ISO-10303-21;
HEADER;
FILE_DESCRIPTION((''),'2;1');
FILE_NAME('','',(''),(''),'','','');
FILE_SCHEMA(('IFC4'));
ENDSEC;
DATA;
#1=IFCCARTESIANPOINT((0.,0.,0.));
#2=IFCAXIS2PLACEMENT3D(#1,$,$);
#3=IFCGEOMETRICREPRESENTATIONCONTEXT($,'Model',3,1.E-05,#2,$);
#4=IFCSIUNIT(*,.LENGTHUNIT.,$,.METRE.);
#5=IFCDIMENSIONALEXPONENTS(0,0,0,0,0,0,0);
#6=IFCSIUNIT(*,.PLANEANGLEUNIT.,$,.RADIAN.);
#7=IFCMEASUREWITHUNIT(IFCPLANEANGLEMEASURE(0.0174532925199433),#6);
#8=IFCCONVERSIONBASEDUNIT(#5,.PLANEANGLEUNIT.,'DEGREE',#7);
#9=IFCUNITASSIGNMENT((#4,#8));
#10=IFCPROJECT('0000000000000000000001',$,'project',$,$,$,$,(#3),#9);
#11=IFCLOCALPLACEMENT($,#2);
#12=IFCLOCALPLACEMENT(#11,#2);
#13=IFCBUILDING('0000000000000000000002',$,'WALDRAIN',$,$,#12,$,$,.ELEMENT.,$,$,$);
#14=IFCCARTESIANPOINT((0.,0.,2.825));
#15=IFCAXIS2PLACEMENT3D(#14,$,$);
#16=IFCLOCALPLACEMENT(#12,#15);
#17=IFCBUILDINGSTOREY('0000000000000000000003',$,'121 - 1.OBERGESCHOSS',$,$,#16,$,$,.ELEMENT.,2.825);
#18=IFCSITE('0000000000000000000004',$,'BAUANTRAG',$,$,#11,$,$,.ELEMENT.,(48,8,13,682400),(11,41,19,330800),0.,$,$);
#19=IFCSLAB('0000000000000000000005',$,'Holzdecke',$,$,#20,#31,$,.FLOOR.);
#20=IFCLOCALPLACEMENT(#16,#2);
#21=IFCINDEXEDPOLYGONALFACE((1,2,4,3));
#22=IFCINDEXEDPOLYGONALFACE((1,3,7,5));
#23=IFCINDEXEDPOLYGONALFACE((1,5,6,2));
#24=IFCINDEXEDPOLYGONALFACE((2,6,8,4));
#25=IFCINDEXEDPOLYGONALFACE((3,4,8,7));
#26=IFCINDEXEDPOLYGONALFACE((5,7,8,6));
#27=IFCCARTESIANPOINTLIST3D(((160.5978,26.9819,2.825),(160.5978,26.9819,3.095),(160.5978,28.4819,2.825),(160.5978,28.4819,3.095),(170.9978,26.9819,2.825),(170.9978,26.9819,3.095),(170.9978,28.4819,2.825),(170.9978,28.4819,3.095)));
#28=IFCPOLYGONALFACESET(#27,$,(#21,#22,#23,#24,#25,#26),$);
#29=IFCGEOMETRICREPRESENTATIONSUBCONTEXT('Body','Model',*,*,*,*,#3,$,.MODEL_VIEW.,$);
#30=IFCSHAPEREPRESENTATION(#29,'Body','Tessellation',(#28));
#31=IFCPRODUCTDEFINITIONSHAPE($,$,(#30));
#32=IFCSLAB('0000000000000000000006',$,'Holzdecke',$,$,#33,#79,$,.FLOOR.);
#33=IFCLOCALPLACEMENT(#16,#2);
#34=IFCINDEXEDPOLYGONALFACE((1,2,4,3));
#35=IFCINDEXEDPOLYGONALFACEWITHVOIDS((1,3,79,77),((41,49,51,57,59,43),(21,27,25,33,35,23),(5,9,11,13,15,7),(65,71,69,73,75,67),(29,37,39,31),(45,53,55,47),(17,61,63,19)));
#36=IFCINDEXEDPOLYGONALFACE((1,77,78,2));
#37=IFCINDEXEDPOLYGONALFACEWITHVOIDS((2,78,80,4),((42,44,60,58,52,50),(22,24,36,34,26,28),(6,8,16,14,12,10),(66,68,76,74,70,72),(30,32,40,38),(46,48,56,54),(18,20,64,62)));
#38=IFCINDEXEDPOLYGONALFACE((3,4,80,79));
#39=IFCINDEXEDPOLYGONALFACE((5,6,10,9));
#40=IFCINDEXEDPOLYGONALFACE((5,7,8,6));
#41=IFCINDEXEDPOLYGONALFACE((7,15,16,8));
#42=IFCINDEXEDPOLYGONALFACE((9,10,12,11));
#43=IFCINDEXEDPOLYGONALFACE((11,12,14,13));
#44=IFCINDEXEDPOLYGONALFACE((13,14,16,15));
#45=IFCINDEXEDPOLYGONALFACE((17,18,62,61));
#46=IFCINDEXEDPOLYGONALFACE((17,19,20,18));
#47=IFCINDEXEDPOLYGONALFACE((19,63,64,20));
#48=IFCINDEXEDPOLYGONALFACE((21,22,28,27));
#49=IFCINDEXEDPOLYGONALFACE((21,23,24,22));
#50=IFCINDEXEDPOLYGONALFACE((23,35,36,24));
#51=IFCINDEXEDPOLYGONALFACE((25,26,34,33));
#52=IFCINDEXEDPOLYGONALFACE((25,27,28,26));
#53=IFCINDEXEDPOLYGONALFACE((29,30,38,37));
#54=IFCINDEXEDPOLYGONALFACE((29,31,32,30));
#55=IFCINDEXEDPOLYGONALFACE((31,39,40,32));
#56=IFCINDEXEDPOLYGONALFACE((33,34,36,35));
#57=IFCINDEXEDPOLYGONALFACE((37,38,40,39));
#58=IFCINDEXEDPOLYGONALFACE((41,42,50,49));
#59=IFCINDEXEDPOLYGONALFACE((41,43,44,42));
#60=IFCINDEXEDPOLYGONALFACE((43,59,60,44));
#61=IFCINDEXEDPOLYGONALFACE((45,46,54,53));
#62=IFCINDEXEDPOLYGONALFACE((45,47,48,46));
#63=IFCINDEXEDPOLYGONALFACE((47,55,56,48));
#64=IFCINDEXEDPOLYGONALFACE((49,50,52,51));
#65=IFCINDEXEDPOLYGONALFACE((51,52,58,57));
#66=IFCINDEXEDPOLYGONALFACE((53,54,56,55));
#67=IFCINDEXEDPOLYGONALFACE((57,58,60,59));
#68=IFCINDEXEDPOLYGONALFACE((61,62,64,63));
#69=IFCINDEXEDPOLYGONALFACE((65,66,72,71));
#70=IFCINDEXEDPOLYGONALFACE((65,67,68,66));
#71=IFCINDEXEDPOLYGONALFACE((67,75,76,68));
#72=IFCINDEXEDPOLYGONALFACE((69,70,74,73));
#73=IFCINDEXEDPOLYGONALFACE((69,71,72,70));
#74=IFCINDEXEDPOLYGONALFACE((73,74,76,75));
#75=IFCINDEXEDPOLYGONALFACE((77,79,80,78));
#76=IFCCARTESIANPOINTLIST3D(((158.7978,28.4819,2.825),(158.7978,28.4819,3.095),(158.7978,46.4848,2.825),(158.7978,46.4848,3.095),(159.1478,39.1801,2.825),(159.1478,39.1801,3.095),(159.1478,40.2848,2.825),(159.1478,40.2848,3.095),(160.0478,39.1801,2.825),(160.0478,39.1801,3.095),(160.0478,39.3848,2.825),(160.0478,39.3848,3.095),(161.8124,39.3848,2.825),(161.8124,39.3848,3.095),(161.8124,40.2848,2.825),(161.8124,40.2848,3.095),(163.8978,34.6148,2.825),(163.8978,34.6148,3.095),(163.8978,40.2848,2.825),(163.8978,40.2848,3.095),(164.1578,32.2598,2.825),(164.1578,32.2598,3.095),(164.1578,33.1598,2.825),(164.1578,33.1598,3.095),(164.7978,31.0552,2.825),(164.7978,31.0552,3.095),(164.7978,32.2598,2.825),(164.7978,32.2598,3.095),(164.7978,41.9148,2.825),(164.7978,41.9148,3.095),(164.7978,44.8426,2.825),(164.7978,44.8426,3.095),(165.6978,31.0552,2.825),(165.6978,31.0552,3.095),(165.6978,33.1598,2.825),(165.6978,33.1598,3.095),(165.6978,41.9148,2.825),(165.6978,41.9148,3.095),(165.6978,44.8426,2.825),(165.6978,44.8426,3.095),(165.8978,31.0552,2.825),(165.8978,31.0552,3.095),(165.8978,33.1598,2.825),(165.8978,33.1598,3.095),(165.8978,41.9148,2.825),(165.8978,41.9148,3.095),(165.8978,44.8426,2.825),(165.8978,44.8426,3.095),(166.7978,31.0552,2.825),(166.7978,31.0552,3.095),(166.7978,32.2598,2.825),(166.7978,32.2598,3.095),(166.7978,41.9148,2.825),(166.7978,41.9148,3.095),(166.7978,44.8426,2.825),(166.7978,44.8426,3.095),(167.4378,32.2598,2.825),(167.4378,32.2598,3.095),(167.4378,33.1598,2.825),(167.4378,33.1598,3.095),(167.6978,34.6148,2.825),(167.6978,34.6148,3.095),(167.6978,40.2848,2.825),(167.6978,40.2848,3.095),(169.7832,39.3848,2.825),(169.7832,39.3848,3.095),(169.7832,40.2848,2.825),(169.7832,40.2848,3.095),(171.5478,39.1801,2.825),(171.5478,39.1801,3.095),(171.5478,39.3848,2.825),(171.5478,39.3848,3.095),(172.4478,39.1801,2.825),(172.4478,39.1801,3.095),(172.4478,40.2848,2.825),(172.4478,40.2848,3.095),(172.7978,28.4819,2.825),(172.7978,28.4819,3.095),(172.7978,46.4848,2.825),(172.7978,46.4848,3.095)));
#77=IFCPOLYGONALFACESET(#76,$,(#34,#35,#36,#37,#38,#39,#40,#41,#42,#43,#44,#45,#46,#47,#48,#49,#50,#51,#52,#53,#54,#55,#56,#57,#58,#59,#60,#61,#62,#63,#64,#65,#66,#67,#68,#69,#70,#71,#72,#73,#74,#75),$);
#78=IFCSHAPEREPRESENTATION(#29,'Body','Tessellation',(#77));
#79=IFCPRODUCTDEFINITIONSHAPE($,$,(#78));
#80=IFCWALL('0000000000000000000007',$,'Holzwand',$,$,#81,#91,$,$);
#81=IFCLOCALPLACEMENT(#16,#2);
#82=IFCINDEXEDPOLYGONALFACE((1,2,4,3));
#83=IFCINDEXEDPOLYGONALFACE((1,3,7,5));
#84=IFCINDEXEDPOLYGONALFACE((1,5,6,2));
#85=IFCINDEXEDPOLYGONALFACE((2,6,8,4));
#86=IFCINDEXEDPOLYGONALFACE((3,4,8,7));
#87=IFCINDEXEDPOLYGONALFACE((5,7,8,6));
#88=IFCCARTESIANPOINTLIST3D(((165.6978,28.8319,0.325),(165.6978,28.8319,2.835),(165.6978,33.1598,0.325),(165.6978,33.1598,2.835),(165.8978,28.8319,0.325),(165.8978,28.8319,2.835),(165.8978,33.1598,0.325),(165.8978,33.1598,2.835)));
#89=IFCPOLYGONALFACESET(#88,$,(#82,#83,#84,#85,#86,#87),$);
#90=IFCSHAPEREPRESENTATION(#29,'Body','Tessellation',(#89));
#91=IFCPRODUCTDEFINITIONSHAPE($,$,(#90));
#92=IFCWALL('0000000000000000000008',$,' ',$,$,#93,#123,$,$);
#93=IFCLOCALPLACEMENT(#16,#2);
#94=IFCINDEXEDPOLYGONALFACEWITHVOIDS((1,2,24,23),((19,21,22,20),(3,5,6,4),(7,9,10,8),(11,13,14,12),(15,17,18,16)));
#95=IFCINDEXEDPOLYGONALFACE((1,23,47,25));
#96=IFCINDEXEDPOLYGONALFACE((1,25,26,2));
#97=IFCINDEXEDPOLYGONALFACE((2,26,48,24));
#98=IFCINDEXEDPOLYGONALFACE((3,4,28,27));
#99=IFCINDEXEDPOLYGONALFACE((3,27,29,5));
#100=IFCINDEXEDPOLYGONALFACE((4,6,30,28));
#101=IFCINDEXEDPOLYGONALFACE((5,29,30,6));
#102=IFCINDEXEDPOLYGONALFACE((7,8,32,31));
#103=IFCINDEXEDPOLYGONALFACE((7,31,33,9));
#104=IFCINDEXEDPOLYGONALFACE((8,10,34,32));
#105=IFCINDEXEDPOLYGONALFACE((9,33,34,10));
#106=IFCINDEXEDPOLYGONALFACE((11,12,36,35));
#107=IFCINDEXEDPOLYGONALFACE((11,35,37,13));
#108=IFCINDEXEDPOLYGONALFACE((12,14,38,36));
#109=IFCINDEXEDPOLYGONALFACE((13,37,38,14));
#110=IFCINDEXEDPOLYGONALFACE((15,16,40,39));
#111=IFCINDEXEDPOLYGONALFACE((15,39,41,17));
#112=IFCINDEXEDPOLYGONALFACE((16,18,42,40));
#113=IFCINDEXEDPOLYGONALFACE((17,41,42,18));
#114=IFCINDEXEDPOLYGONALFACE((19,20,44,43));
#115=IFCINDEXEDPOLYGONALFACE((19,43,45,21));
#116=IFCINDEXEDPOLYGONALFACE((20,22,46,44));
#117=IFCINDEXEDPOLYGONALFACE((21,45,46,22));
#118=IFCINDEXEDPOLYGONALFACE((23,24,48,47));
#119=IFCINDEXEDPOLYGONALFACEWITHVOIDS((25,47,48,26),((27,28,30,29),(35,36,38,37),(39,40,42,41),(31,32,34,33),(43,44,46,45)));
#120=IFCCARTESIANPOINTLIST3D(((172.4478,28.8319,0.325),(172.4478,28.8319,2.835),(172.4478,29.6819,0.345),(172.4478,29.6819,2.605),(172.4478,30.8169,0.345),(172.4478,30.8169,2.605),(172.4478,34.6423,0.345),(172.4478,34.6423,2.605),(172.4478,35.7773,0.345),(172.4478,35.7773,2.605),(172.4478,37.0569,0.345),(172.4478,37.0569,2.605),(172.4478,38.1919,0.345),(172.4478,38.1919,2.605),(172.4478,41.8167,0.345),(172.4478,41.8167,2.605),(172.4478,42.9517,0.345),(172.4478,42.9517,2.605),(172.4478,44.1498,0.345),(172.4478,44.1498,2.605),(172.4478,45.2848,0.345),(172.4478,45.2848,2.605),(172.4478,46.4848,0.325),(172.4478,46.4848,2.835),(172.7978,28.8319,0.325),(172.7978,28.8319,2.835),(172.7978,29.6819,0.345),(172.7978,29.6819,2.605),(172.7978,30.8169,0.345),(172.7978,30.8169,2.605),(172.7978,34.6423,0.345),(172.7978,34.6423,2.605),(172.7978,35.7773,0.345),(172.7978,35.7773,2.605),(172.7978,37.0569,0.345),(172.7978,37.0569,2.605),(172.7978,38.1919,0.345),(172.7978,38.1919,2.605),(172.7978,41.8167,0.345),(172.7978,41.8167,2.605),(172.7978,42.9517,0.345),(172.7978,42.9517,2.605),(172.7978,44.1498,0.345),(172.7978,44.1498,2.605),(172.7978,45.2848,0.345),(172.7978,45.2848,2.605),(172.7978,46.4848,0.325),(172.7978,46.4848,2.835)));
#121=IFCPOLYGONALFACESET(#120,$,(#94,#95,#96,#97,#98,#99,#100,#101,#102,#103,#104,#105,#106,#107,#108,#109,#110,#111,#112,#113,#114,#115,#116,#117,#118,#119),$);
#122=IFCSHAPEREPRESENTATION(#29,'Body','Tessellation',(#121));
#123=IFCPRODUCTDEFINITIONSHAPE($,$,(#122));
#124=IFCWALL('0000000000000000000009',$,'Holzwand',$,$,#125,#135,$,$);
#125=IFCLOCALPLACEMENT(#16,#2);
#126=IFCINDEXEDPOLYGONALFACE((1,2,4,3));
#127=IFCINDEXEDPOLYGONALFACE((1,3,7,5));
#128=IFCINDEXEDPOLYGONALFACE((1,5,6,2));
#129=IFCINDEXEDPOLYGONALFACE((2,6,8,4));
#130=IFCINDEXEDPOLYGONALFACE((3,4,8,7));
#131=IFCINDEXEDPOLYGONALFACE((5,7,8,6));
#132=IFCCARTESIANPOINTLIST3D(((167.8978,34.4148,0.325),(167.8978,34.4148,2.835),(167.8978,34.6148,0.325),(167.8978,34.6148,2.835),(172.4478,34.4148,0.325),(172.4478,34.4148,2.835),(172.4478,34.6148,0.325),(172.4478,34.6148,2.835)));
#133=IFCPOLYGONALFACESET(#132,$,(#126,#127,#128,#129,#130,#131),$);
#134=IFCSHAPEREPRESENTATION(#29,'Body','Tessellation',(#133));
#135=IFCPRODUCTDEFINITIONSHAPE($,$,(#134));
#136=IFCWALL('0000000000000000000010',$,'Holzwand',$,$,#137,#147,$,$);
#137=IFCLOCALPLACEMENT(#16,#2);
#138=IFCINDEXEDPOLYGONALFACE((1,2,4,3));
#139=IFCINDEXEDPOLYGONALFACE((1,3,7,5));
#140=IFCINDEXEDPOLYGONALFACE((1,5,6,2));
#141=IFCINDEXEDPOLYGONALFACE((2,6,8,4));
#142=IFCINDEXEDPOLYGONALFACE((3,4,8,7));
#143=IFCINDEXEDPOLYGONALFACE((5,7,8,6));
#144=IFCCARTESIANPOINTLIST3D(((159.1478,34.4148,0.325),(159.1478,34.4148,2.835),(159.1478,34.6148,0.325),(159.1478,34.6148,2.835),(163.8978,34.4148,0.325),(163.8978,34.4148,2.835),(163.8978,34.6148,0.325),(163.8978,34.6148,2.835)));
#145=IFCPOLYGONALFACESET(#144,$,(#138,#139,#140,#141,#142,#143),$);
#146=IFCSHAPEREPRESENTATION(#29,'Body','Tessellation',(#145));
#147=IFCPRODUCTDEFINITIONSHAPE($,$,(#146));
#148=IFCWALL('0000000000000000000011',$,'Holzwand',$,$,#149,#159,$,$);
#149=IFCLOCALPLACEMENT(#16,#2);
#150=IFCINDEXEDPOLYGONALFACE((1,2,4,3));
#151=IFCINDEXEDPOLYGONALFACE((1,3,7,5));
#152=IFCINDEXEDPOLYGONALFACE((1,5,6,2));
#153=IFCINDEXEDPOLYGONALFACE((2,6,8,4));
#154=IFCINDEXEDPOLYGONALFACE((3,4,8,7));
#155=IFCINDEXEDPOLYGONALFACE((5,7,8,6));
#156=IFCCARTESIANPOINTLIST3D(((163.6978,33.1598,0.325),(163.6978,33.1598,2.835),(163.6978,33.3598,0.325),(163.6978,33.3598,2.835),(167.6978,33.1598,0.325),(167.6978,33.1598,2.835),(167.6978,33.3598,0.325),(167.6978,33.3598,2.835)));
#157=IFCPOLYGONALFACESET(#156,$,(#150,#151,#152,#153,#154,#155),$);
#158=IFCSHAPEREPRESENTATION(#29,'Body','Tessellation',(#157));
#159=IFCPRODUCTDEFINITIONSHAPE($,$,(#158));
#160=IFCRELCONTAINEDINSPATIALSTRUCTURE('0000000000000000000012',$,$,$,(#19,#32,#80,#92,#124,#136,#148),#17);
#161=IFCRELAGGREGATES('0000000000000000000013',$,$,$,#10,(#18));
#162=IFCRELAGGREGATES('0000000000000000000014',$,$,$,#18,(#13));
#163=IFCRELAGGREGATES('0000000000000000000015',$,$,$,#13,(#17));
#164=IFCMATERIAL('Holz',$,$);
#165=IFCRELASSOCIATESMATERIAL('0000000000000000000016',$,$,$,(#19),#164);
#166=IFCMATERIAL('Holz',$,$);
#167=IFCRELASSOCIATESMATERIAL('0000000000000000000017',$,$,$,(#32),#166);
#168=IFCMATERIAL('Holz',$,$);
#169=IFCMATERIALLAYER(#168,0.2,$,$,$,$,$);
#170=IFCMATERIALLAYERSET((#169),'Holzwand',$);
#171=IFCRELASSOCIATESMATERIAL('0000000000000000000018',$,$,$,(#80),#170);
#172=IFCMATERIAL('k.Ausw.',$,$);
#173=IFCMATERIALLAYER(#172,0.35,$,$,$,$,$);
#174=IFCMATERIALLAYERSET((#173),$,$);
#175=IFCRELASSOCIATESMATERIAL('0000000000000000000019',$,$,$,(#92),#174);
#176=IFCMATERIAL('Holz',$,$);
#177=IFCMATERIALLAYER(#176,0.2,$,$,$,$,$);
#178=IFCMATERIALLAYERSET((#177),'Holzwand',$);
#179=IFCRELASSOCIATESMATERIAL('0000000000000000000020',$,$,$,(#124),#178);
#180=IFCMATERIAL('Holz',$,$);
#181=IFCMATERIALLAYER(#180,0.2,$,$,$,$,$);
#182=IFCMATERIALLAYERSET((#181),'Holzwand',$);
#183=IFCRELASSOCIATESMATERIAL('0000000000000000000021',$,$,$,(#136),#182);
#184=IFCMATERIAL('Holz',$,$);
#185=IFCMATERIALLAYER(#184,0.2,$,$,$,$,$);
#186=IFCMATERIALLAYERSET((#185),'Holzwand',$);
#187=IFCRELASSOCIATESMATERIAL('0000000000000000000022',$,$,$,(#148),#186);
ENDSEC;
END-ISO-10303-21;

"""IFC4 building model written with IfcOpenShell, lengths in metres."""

from ifc_helpers import new_model, entity, si_unit, converted_unit, frame, frame_2d, origin, origin_with_axes, place, context, subcontext, project, spatial, polyline, rectangle, outline, extrude, material, layer, layer_set, layer_usage, element, save


model = new_model("IFC4")

# Units and contexts
model_context = context("Model", 3, precision=1e-05, world=origin())
body_context = subcontext(model_context, "Body", "Model", "MODEL_VIEW")
ifc_project = project(units=[si_unit("LENGTHUNIT", "METRE"), converted_unit("PLANEANGLEUNIT", "DEGREE", entity("IfcPlaneAngleMeasure", 0.0174532925199433), si_unit("PLANEANGLEUNIT", "RADIAN"), dimensions=[0, 0, 0, 0, 0, 0, 0])], contexts=[model_context])

# Site, building, storey
site_placement = place(None, origin())
site = spatial("IfcSite", under=ifc_project, at=site_placement, Name="BAUANTRAG", CompositionType="ELEMENT", RefLatitude=(48, 8, 13, 682400), RefLongitude=(11, 41, 19, 330800), RefElevation=0.0)
building_placement = place(site_placement, origin())
building = spatial("IfcBuilding", under=site, at=building_placement, Name="WALDRAIN", CompositionType="ELEMENT")
storey_placement = place(building_placement, frame((0.0, 0.0, 2.825)))
storey = spatial("IfcBuildingStorey", under=building, at=storey_placement, Name="121 - 1.OBERGESCHOSS", CompositionType="ELEMENT", Elevation=2.825)

# Slab
ifc_material_1 = material(Name="Holz")
slab_1_placement = place(storey_placement, frame((160.5978, 26.9819, 2.825)))
element("IfcSlab", 1, at=slab_1_placement, inside=storey, material=ifc_material_1, Name="Holzdecke", PredefinedType="FLOOR", context=body_context, shape_type="SweptSolid", body=[
    extrude(rectangle(XDim=10.4, YDim=1.5, at=frame_2d((5.2, 0.75), x_axis=(1.0, 0.0))), origin_with_axes(), (0.0, 0.0, 1.0), 0.27),
])

# Slab, opening
ifc_material_2 = material(Name="Holz")
slab_2_placement = place(storey_placement, frame((158.7978, 28.4819, 2.825)))
slab_2 = element("IfcSlab", 2, at=slab_2_placement, inside=storey, material=ifc_material_2, Name="Holzdecke", PredefinedType="FLOOR", context=body_context, shape_type="SweptSolid", body=[
    extrude(outline(polyline([(0.0, 0.0), (14.0, 0.0), (14.0, 18.0029), (0.0, 18.0029), (0.0, 0.0)]), holes=[polyline([(5.1, 6.1329), (5.1, 11.8029), (8.9, 11.8029), (8.9, 6.1329), (5.1, 6.1329)]), polyline([(6.9, 13.4329), (6.0, 13.4329), (6.0, 16.3607), (6.9, 16.3607), (6.9, 13.4329)]), polyline([(7.1, 16.3607), (8.0, 16.3607), (8.0, 13.4329), (7.1, 13.4329), (7.1, 16.3607)]), polyline([(12.75, 10.6981), (12.75, 10.9029), (10.9854, 10.9029), (10.9854, 11.8029), (13.65, 11.8029), (13.65, 10.6981), (12.75, 10.6981)]), polyline([(6.0, 3.7779), (5.36, 3.7779), (5.36, 4.6779), (6.9, 4.6779), (6.9, 2.5733), (6.0, 2.5733), (6.0, 3.7779)]), polyline([(7.1, 2.5733), (7.1, 4.6779), (8.64, 4.6779), (8.64, 3.7779), (8.0, 3.7779), (8.0, 2.5733), (7.1, 2.5733)])]), origin_with_axes(), (0.0, 0.0, 1.0), 0.27),
])
opening_1_placement = place(slab_2_placement, frame((0.35, 10.6981, 0.0)))
element("IfcOpeningElement", 3, at=opening_1_placement, cuts=slab_2, ObjectType="Opening", context=body_context, shape_type="SweptSolid", body=[
    extrude(outline(polyline([(1.4764, 0.6682), (-1.1882, 0.6682), (-1.1882, -0.4365), (-0.2882, -0.4365), (-0.2882, -0.2318), (1.4764, -0.2318), (1.4764, 0.6682)])), frame((1.1882, 0.4365, 0.0), z_axis=(0.0, 0.0, 1.0), x_axis=(1.0, 0.0, 0.0)), (0.0, 0.0, 1.0), 0.27),
])

# Wall
ifc_material_3 = material(Name="Holz")
ifc_layer_1 = layer(ifc_material_3, 0.2)
ifc_layer_set_1 = layer_set([ifc_layer_1], Name="Holzwand")
ifc_layer_usage_1 = layer_usage(ifc_layer_set_1, "AXIS2", "POSITIVE", 0.0)
wall_1_placement = place(storey_placement, frame((165.6978, 33.1598, 0.325), z_axis=(0.0, 0.0, 1.0), x_axis=(0.0, -1.0, 0.0)))
element("IfcWall", 4, at=wall_1_placement, inside=storey, material=ifc_layer_usage_1, Name="Holzwand", context=body_context, shape_type="SweptSolid", body=[
    extrude(rectangle(XDim=4.3279, YDim=0.2, at=frame_2d((2.1639, 0.1), x_axis=(1.0, 0.0))), origin_with_axes(), (0.0, 0.0, 1.0), 2.51),
])

# Wall, openings
ifc_material_4 = material(Name="k.Ausw.")
ifc_layer_2 = layer(ifc_material_4, 0.35)
ifc_layer_set_2 = layer_set([ifc_layer_2])
ifc_layer_usage_2 = layer_usage(ifc_layer_set_2, "AXIS2", "POSITIVE", 0.0)
wall_2_placement = place(storey_placement, frame((172.7978, 28.8319, 0.325), z_axis=(0.0, 0.0, 1.0), x_axis=(0.0, 1.0, 0.0)))
wall_2 = element("IfcWall", 5, at=wall_2_placement, inside=storey, material=ifc_layer_usage_2, Name=" ", context=body_context, shape_type="SweptSolid", body=[
    extrude(rectangle(XDim=17.6529, YDim=0.35, at=frame_2d((8.8264, 0.175), x_axis=(1.0, 0.0))), origin_with_axes(), (0.0, 0.0, 1.0), 2.51),
])
opening_2_placement = place(wall_2_placement, frame((1.985, 0.35, 0.02), z_axis=(0.0, -1.0, 0.0), x_axis=(0.0, 0.0, 1.0)))
element("IfcOpeningElement", 6, at=opening_2_placement, cuts=wall_2, ObjectType="Opening", context=body_context, shape_type="SweptSolid", body=[
    extrude(outline(polyline([(0.0, 1.135), (2.26, 1.135), (2.26, 0.0), (0.0, 0.0), (0.0, 1.135)])), origin_with_axes(), (0.0, 0.0, 1.0), 0.35),
])
opening_3_placement = place(wall_2_placement, frame((9.36, 0.35, 0.02), z_axis=(0.0, -1.0, 0.0), x_axis=(0.0, 0.0, 1.0)))
element("IfcOpeningElement", 7, at=opening_3_placement, cuts=wall_2, ObjectType="Opening", context=body_context, shape_type="SweptSolid", body=[
    extrude(outline(polyline([(0.0, 1.135), (2.26, 1.135), (2.26, 0.0), (0.0, 0.0), (0.0, 1.135)])), origin_with_axes(), (0.0, 0.0, 1.0), 0.35),
])
opening_4_placement = place(wall_2_placement, frame((6.9454, 0.35, 0.02), z_axis=(0.0, -1.0, 0.0), x_axis=(0.0, 0.0, 1.0)))
element("IfcOpeningElement", 8, at=opening_4_placement, cuts=wall_2, ObjectType="Opening", context=body_context, shape_type="SweptSolid", body=[
    extrude(outline(polyline([(0.0, 1.135), (2.26, 1.135), (2.26, 0.0), (0.0, 0.0), (0.0, 1.135)])), origin_with_axes(), (0.0, 0.0, 1.0), 0.35),
])
opening_5_placement = place(wall_2_placement, frame((16.4529, 0.35, 0.02), z_axis=(0.0, -1.0, 0.0), x_axis=(0.0, 0.0, 1.0)))
element("IfcOpeningElement", 9, at=opening_5_placement, cuts=wall_2, ObjectType="Opening", context=body_context, shape_type="SweptSolid", body=[
    extrude(outline(polyline([(0.0, 1.135), (2.26, 1.135), (2.26, 0.0), (0.0, 0.0), (0.0, 1.135)])), origin_with_axes(), (0.0, 0.0, 1.0), 0.35),
])
opening_6_placement = place(wall_2_placement, frame((14.1198, 0.35, 0.02), z_axis=(0.0, -1.0, 0.0), x_axis=(0.0, 0.0, 1.0)))
element("IfcOpeningElement", 10, at=opening_6_placement, cuts=wall_2, ObjectType="Opening", context=body_context, shape_type="SweptSolid", body=[
    extrude(outline(polyline([(0.0, 1.135), (2.26, 1.135), (2.26, 0.0), (0.0, 0.0), (0.0, 1.135)])), origin_with_axes(), (0.0, 0.0, 1.0), 0.35),
])

# Walls
ifc_material_5 = material(Name="Holz")
ifc_layer_3 = layer(ifc_material_5, 0.2)
ifc_layer_set_3 = layer_set([ifc_layer_3], Name="Holzwand")
ifc_layer_usage_3 = layer_usage(ifc_layer_set_3, "AXIS2", "POSITIVE", 0.0)
wall_3_placement = place(storey_placement, frame((167.8978, 34.4148, 0.325)))
element("IfcWall", 11, at=wall_3_placement, inside=storey, material=ifc_layer_usage_3, Name="Holzwand", context=body_context, shape_type="SweptSolid", body=[
    extrude(rectangle(XDim=4.55, YDim=0.2, at=frame_2d((2.275, 0.1), x_axis=(1.0, 0.0))), origin_with_axes(), (0.0, 0.0, 1.0), 2.51),
])
ifc_material_6 = material(Name="Holz")
ifc_layer_4 = layer(ifc_material_6, 0.2)
ifc_layer_set_4 = layer_set([ifc_layer_4], Name="Holzwand")
ifc_layer_usage_4 = layer_usage(ifc_layer_set_4, "AXIS2", "POSITIVE", 0.0)
wall_4_placement = place(storey_placement, frame((159.1478, 34.4148, 0.325)))
element("IfcWall", 12, at=wall_4_placement, inside=storey, material=ifc_layer_usage_4, Name="Holzwand", context=body_context, shape_type="SweptSolid", body=[
    extrude(rectangle(XDim=4.75, YDim=0.2, at=frame_2d((2.375, 0.1), x_axis=(1.0, 0.0))), origin_with_axes(), (0.0, 0.0, 1.0), 2.51),
])
ifc_material_7 = material(Name="Holz")
ifc_layer_5 = layer(ifc_material_7, 0.2)
ifc_layer_set_5 = layer_set([ifc_layer_5], Name="Holzwand")
ifc_layer_usage_5 = layer_usage(ifc_layer_set_5, "AXIS2", "POSITIVE", 0.0)
wall_5_placement = place(storey_placement, frame((167.6978, 33.3598, 0.325), z_axis=(0.0, 0.0, 1.0), x_axis=(-1.0, 0.0, 0.0)))
element("IfcWall", 13, at=wall_5_placement, inside=storey, material=ifc_layer_usage_5, Name="Holzwand", context=body_context, shape_type="SweptSolid", body=[
    extrude(rectangle(XDim=4.0, YDim=0.2, at=frame_2d((2.0, 0.1), x_axis=(1.0, 0.0))), origin_with_axes(), (0.0, 0.0, 1.0), 2.51),
])

save(model, "model.ifc")
